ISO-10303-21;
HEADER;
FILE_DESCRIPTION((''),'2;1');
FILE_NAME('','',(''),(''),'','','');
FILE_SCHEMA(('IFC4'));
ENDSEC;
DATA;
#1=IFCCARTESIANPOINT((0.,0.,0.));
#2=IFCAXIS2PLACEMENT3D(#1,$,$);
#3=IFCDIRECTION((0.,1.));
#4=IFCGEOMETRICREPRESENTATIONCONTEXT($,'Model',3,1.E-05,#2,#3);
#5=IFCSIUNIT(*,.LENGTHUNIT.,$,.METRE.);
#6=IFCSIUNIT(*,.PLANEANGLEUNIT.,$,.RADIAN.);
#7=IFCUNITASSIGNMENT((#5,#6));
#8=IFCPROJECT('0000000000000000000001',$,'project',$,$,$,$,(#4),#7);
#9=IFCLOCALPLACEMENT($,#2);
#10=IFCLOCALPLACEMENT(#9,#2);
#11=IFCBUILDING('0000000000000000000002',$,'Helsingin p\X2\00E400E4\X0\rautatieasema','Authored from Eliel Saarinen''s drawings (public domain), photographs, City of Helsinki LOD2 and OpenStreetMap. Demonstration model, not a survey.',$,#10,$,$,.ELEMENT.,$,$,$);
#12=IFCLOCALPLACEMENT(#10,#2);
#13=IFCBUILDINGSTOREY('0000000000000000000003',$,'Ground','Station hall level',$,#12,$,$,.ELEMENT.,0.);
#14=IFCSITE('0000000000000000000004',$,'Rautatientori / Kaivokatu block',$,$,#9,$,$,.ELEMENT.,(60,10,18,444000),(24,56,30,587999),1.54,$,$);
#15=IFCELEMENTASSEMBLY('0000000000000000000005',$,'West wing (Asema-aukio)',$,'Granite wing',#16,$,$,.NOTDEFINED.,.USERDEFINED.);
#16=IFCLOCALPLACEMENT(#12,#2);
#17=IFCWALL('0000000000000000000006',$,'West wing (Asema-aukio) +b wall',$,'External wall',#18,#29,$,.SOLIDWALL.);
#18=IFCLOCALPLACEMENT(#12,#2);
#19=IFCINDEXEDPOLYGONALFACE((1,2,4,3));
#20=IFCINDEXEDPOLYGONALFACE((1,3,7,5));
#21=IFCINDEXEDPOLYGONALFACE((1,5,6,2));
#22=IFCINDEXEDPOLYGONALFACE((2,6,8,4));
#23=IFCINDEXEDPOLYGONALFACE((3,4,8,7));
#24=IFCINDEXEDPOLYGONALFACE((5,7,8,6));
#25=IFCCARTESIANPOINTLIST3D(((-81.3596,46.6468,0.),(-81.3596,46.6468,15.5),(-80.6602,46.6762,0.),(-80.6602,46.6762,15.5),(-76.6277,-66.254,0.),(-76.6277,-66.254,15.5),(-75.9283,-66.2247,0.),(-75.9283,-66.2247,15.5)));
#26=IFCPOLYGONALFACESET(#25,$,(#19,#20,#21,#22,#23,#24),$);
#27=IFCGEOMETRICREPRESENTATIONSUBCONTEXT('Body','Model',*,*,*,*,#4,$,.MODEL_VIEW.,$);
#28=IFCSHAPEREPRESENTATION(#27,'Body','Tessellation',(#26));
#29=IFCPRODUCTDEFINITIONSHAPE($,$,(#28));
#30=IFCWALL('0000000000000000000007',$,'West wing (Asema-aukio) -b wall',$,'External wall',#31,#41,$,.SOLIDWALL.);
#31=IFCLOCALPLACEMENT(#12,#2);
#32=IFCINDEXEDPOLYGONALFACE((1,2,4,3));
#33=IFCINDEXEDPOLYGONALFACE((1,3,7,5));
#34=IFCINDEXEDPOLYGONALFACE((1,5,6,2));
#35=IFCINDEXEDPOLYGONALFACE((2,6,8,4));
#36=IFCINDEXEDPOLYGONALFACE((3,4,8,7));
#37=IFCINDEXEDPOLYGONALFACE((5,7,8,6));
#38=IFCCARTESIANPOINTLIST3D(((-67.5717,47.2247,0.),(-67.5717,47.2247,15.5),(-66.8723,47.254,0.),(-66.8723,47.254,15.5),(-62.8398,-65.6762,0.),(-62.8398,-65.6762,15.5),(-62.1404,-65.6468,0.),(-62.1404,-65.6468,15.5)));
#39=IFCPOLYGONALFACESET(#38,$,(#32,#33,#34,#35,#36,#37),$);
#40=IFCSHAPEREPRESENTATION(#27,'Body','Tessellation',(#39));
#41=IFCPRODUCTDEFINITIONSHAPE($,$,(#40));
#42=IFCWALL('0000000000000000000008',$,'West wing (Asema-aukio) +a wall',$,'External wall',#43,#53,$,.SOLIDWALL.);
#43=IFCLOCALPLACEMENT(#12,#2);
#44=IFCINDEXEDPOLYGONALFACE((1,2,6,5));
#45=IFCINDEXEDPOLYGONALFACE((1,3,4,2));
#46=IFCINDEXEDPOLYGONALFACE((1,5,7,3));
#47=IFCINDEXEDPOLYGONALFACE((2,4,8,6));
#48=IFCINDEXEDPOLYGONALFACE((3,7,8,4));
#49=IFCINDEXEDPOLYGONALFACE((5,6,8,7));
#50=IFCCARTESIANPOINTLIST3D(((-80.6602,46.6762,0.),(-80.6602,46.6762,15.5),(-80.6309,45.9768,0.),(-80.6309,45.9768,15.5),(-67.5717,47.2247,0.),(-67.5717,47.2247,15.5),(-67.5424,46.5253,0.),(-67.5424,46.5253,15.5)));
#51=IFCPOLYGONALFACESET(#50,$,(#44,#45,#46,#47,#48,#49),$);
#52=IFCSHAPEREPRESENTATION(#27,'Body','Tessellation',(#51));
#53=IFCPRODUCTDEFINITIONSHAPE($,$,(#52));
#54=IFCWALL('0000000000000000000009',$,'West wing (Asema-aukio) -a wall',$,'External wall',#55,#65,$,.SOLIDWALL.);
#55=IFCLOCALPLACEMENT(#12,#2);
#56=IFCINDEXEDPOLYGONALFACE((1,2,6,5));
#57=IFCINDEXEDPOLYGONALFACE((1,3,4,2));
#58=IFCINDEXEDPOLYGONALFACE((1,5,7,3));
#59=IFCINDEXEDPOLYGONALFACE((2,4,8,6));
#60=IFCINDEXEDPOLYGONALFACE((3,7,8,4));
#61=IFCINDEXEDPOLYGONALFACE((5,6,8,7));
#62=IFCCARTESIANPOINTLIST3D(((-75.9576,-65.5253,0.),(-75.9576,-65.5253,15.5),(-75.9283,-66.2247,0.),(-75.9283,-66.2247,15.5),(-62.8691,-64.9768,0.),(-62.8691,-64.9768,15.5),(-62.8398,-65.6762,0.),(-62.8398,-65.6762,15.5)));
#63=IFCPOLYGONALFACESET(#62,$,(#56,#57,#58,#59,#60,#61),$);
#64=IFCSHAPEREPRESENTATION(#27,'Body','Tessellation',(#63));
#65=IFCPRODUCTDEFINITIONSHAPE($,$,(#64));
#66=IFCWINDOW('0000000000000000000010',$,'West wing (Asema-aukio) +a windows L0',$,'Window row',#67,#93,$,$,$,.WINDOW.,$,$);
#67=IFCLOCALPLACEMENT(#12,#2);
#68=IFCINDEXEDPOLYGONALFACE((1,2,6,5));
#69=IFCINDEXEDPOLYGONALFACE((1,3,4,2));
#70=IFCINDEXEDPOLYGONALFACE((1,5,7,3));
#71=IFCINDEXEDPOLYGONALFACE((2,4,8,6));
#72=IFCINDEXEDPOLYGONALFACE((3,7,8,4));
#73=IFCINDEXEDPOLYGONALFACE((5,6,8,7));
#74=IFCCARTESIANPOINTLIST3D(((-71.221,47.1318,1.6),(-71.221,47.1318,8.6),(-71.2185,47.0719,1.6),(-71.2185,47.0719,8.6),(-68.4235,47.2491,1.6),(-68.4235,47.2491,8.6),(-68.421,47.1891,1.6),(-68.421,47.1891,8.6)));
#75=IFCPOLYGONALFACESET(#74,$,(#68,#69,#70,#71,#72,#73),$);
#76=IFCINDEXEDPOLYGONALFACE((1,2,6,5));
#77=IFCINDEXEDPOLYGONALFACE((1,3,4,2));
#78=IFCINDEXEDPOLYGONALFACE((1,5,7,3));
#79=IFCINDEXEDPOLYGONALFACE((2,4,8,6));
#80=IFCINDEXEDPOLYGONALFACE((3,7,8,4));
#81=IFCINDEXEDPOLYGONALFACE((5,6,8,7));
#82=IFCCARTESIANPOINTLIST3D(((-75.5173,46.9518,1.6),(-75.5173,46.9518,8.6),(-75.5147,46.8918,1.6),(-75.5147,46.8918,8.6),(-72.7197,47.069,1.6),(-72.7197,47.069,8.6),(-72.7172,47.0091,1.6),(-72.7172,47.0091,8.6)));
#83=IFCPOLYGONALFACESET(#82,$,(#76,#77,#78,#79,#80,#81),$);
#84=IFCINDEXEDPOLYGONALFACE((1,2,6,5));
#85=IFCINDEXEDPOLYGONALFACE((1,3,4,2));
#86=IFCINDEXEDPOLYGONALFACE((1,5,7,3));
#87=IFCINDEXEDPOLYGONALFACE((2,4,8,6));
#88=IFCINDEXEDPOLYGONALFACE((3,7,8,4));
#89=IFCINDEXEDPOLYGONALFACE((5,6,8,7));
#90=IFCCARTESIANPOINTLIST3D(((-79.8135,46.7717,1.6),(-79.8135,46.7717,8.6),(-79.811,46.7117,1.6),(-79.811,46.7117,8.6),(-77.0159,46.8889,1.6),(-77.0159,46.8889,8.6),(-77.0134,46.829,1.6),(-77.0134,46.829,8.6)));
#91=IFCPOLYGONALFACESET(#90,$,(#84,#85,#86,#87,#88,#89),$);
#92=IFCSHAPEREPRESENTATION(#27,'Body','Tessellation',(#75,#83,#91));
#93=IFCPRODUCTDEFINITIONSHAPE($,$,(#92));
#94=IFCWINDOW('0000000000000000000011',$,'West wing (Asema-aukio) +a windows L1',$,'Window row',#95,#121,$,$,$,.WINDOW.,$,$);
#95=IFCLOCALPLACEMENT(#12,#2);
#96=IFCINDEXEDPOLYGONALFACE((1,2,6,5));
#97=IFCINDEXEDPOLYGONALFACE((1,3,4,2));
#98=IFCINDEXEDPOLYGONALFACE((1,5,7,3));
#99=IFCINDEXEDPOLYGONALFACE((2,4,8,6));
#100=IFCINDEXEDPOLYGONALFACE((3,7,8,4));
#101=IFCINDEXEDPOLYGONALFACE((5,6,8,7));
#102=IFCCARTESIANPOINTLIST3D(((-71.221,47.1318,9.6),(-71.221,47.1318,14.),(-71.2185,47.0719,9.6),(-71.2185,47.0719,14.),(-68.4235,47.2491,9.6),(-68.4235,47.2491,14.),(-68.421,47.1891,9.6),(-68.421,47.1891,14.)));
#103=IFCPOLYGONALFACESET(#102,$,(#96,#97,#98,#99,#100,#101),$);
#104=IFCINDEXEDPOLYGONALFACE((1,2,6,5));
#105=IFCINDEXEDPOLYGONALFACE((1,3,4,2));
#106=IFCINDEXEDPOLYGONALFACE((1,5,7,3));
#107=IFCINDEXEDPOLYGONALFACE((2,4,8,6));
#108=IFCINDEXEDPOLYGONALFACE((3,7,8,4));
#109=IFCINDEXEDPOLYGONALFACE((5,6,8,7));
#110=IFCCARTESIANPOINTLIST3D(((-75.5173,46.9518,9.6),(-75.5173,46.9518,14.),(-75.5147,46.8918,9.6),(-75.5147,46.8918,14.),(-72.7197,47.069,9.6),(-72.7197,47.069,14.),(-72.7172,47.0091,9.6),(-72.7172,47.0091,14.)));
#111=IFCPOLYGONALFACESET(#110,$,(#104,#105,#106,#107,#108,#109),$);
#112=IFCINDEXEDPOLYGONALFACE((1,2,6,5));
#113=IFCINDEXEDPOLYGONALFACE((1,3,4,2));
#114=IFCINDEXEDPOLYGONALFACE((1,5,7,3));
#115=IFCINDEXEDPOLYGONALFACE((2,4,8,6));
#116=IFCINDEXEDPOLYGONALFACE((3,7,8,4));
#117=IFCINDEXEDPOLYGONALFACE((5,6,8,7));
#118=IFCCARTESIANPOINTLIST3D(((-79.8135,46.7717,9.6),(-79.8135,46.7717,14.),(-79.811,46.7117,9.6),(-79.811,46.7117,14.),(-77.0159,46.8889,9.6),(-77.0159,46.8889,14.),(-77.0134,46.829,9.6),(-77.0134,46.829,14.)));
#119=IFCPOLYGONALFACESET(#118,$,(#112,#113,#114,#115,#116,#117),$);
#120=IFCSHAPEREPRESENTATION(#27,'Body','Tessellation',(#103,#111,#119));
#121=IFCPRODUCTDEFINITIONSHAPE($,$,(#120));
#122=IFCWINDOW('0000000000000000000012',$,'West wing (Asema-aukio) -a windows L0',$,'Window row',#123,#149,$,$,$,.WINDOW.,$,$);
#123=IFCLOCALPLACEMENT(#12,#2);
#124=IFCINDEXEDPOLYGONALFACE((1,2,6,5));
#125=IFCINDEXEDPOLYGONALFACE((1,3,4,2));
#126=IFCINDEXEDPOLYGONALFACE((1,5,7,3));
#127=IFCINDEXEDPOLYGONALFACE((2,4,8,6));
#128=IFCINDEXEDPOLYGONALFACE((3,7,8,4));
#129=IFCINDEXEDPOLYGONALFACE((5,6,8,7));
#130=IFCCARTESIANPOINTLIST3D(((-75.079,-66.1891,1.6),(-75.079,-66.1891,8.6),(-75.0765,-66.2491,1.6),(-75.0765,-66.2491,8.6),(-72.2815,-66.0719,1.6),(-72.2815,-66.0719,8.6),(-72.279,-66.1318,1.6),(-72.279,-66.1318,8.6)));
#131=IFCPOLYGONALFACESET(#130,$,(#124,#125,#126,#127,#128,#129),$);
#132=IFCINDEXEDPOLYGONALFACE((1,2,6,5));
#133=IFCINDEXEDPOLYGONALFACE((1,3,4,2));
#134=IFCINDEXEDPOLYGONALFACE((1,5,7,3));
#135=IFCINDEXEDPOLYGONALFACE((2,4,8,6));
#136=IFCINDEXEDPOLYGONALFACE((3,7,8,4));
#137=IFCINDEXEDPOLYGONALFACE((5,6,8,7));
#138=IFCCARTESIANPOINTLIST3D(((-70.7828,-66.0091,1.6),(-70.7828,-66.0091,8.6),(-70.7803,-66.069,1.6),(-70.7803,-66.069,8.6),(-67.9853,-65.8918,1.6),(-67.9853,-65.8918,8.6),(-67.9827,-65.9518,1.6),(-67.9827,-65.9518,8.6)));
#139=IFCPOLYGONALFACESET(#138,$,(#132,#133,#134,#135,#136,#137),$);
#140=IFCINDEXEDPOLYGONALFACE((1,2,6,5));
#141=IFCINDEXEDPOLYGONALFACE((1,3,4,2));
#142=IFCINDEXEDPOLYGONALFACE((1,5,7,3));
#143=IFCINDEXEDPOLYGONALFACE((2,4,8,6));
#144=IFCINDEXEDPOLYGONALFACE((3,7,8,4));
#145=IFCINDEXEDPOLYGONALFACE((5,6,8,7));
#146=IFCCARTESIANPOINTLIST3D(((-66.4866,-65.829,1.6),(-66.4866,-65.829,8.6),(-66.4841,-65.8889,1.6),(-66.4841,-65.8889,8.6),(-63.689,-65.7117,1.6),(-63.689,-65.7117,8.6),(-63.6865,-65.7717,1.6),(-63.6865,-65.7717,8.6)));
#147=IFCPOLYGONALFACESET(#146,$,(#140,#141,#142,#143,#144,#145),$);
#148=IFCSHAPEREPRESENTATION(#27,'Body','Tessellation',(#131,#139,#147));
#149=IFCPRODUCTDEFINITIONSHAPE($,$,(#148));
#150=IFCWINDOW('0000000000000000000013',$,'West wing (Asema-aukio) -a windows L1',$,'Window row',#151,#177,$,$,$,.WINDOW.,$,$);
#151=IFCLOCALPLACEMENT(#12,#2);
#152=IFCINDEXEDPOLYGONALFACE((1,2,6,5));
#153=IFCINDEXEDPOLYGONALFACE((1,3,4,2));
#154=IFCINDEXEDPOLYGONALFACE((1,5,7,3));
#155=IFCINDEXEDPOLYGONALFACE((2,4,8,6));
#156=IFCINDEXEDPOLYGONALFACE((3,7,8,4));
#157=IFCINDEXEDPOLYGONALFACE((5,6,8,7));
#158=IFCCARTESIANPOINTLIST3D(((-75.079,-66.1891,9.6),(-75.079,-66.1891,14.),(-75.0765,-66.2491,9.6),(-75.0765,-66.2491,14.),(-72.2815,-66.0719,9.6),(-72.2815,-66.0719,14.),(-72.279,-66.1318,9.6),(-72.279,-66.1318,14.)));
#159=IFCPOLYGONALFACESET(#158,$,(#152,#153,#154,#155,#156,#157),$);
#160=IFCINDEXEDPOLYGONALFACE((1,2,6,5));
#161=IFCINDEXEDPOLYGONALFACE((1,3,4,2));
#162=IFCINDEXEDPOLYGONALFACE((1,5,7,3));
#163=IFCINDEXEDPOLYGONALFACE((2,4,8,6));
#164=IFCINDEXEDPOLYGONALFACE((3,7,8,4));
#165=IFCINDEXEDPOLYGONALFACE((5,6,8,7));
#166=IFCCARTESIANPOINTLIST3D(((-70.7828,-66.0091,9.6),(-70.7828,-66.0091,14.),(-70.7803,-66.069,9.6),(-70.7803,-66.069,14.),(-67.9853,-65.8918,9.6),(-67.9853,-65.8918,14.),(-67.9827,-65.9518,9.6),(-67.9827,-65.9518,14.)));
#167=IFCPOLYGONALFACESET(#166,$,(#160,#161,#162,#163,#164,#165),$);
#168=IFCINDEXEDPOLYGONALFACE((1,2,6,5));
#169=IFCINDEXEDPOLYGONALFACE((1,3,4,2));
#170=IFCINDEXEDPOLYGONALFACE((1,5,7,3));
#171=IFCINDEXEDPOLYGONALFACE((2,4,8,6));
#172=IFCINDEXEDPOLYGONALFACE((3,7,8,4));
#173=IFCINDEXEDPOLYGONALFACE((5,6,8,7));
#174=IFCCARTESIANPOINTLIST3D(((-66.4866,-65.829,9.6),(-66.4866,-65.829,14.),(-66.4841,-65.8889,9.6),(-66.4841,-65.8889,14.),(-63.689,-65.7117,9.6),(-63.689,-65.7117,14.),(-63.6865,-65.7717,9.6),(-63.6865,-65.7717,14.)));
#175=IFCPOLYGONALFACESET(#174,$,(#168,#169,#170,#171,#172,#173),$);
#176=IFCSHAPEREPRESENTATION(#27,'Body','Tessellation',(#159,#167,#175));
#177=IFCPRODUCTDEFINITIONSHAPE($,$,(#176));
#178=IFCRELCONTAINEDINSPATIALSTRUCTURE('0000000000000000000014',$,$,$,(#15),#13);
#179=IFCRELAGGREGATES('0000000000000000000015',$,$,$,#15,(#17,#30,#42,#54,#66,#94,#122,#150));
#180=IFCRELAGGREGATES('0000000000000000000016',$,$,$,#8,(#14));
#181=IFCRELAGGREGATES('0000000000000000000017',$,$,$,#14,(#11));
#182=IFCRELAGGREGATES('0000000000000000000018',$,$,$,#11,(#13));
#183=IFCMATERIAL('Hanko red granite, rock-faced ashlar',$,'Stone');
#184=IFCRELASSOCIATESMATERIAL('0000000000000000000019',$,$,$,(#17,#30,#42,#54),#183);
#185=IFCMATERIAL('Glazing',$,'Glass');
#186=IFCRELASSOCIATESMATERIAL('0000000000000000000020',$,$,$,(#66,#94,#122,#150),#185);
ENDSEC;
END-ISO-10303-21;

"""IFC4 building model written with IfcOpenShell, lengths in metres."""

from ifc_helpers import new_model, si_unit, direction, frame, frame_2d, origin, place, context, subcontext, project, spatial, rectangle, extrude, material, element, aggregate, save


model = new_model("IFC4")

# Units and contexts
model_context = context("Model", 3, precision=1e-05, world=origin(), true_north=direction((0.0, 1.0)))
body_context = subcontext(model_context, "Body", "Model", "MODEL_VIEW")
ifc_project = project(units=[si_unit("LENGTHUNIT", "METRE"), si_unit("PLANEANGLEUNIT", "RADIAN")], contexts=[model_context])

# Site, building, storey
site_placement = place(None, origin())
site = spatial("IfcSite", under=ifc_project, at=site_placement, Name="Rautatientori / Kaivokatu block", CompositionType="ELEMENT", RefLatitude=(60, 10, 18, 444000), RefLongitude=(24, 56, 30, 587999), RefElevation=1.54)
building_placement = place(site_placement, origin())
building = spatial("IfcBuilding", under=site, at=building_placement, Name="Helsingin päärautatieasema", Description="Authored from Eliel Saarinen's drawings (public domain), photographs, City of Helsinki LOD2 and OpenStreetMap. Demonstration model, not a survey.", CompositionType="ELEMENT")
storey_placement = place(building_placement, origin())
storey = spatial("IfcBuildingStorey", under=building, at=storey_placement, Name="Ground", Description="Station hall level", CompositionType="ELEMENT", Elevation=0.0)

# Element assembly, walls, windows
assembly_placement = place(building_placement, origin())
assembly = element("IfcElementAssembly", 1, at=assembly_placement, inside=storey, Name="West wing (Asema-aukio)", ObjectType="Granite wing", AssemblyPlace="NOTDEFINED", PredefinedType="USERDEFINED")
ifc_material_1 = material(Name="Hanko red granite, rock-faced ashlar", Category="Stone")
wall_1_placement = place(building_placement, origin())
wall_1 = element("IfcWall", 2, at=wall_1_placement, material=ifc_material_1, Name="West wing (Asema-aukio) +b wall", ObjectType="External wall", PredefinedType="SOLIDWALL", context=body_context, shape_type="SweptSolid", body=[
    extrude(rectangle(XDim=113.0, YDim=0.7, at=frame_2d((0.0, 0.0), x_axis=(0.041876, -0.999123))), frame((-78.6439, -9.7889, 0.0)), (0.0, 0.0, 1.0), 15.5),
])
wall_2_placement = place(building_placement, origin())
wall_2 = element("IfcWall", 3, at=wall_2_placement, material=ifc_material_1, Name="West wing (Asema-aukio) -b wall", ObjectType="External wall", PredefinedType="SOLIDWALL", context=body_context, shape_type="SweptSolid", body=[
    extrude(rectangle(XDim=113.0, YDim=0.7, at=frame_2d((0.0, 0.0), x_axis=(-0.041876, 0.999123))), frame((-64.8561, -9.2111, 0.0)), (0.0, 0.0, 1.0), 15.5),
])
wall_3_placement = place(building_placement, origin())
wall_3 = element("IfcWall", 4, at=wall_3_placement, material=ifc_material_1, Name="West wing (Asema-aukio) +a wall", ObjectType="External wall", PredefinedType="SOLIDWALL", context=body_context, shape_type="SweptSolid", body=[
    extrude(rectangle(XDim=13.1, YDim=0.7, at=frame_2d((0.0, 0.0), x_axis=(-0.999123, -0.041876))), frame((-74.1013, 46.6007, 0.0)), (0.0, 0.0, 1.0), 15.5),
])
wall_4_placement = place(building_placement, origin())
wall_4 = element("IfcWall", 5, at=wall_4_placement, material=ifc_material_1, Name="West wing (Asema-aukio) -a wall", ObjectType="External wall", PredefinedType="SOLIDWALL", context=body_context, shape_type="SweptSolid", body=[
    extrude(rectangle(XDim=13.1, YDim=0.7, at=frame_2d((0.0, 0.0), x_axis=(0.999123, 0.041876))), frame((-69.3987, -65.6007, 0.0)), (0.0, 0.0, 1.0), 15.5),
])
ifc_material_2 = material(Name="Glazing", Category="Glass")
window_1_placement = place(building_placement, origin())
window_1 = element("IfcWindow", 6, at=window_1_placement, material=ifc_material_2, Name="West wing (Asema-aukio) +a windows L0", ObjectType="Window row", PredefinedType="WINDOW", context=body_context, shape_type="SweptSolid", body=[
    extrude(rectangle(XDim=2.8, YDim=0.06, at=frame_2d((0.0, 0.0), x_axis=(-0.999123, -0.041876))), frame((-69.821, 47.1605, 1.6)), (0.0, 0.0, 1.0), 7.0),
    extrude(rectangle(XDim=2.8, YDim=0.06, at=frame_2d((0.0, 0.0), x_axis=(-0.999123, -0.041876))), frame((-74.1172, 46.9804, 1.6)), (0.0, 0.0, 1.0), 7.0),
    extrude(rectangle(XDim=2.8, YDim=0.06, at=frame_2d((0.0, 0.0), x_axis=(-0.999123, -0.041876))), frame((-78.4135, 46.8003, 1.6)), (0.0, 0.0, 1.0), 7.0),
])
window_2_placement = place(building_placement, origin())
window_2 = element("IfcWindow", 7, at=window_2_placement, material=ifc_material_2, Name="West wing (Asema-aukio) +a windows L1", ObjectType="Window row", PredefinedType="WINDOW", context=body_context, shape_type="SweptSolid", body=[
    extrude(rectangle(XDim=2.8, YDim=0.06, at=frame_2d((0.0, 0.0), x_axis=(-0.999123, -0.041876))), frame((-69.821, 47.1605, 9.6)), (0.0, 0.0, 1.0), 4.4),
    extrude(rectangle(XDim=2.8, YDim=0.06, at=frame_2d((0.0, 0.0), x_axis=(-0.999123, -0.041876))), frame((-74.1172, 46.9804, 9.6)), (0.0, 0.0, 1.0), 4.4),
    extrude(rectangle(XDim=2.8, YDim=0.06, at=frame_2d((0.0, 0.0), x_axis=(-0.999123, -0.041876))), frame((-78.4135, 46.8003, 9.6)), (0.0, 0.0, 1.0), 4.4),
])
window_3_placement = place(building_placement, origin())
window_3 = element("IfcWindow", 8, at=window_3_placement, material=ifc_material_2, Name="West wing (Asema-aukio) -a windows L0", ObjectType="Window row", PredefinedType="WINDOW", context=body_context, shape_type="SweptSolid", body=[
    extrude(rectangle(XDim=2.8, YDim=0.06, at=frame_2d((0.0, 0.0), x_axis=(0.999123, 0.041876))), frame((-73.679, -66.1605, 1.6)), (0.0, 0.0, 1.0), 7.0),
    extrude(rectangle(XDim=2.8, YDim=0.06, at=frame_2d((0.0, 0.0), x_axis=(0.999123, 0.041876))), frame((-69.3828, -65.9804, 1.6)), (0.0, 0.0, 1.0), 7.0),
    extrude(rectangle(XDim=2.8, YDim=0.06, at=frame_2d((0.0, 0.0), x_axis=(0.999123, 0.041876))), frame((-65.0865, -65.8003, 1.6)), (0.0, 0.0, 1.0), 7.0),
])
window_4_placement = place(building_placement, origin())
window_4 = element("IfcWindow", 9, at=window_4_placement, material=ifc_material_2, Name="West wing (Asema-aukio) -a windows L1", ObjectType="Window row", PredefinedType="WINDOW", context=body_context, shape_type="SweptSolid", body=[
    extrude(rectangle(XDim=2.8, YDim=0.06, at=frame_2d((0.0, 0.0), x_axis=(0.999123, 0.041876))), frame((-73.679, -66.1605, 9.6)), (0.0, 0.0, 1.0), 4.4),
    extrude(rectangle(XDim=2.8, YDim=0.06, at=frame_2d((0.0, 0.0), x_axis=(0.999123, 0.041876))), frame((-69.3828, -65.9804, 9.6)), (0.0, 0.0, 1.0), 4.4),
    extrude(rectangle(XDim=2.8, YDim=0.06, at=frame_2d((0.0, 0.0), x_axis=(0.999123, 0.041876))), frame((-65.0865, -65.8003, 9.6)), (0.0, 0.0, 1.0), 4.4),
])
aggregate(assembly, [wall_1, wall_2, wall_3, wall_4, window_1, window_2, window_3, window_4])

save(model, "model.ifc")
